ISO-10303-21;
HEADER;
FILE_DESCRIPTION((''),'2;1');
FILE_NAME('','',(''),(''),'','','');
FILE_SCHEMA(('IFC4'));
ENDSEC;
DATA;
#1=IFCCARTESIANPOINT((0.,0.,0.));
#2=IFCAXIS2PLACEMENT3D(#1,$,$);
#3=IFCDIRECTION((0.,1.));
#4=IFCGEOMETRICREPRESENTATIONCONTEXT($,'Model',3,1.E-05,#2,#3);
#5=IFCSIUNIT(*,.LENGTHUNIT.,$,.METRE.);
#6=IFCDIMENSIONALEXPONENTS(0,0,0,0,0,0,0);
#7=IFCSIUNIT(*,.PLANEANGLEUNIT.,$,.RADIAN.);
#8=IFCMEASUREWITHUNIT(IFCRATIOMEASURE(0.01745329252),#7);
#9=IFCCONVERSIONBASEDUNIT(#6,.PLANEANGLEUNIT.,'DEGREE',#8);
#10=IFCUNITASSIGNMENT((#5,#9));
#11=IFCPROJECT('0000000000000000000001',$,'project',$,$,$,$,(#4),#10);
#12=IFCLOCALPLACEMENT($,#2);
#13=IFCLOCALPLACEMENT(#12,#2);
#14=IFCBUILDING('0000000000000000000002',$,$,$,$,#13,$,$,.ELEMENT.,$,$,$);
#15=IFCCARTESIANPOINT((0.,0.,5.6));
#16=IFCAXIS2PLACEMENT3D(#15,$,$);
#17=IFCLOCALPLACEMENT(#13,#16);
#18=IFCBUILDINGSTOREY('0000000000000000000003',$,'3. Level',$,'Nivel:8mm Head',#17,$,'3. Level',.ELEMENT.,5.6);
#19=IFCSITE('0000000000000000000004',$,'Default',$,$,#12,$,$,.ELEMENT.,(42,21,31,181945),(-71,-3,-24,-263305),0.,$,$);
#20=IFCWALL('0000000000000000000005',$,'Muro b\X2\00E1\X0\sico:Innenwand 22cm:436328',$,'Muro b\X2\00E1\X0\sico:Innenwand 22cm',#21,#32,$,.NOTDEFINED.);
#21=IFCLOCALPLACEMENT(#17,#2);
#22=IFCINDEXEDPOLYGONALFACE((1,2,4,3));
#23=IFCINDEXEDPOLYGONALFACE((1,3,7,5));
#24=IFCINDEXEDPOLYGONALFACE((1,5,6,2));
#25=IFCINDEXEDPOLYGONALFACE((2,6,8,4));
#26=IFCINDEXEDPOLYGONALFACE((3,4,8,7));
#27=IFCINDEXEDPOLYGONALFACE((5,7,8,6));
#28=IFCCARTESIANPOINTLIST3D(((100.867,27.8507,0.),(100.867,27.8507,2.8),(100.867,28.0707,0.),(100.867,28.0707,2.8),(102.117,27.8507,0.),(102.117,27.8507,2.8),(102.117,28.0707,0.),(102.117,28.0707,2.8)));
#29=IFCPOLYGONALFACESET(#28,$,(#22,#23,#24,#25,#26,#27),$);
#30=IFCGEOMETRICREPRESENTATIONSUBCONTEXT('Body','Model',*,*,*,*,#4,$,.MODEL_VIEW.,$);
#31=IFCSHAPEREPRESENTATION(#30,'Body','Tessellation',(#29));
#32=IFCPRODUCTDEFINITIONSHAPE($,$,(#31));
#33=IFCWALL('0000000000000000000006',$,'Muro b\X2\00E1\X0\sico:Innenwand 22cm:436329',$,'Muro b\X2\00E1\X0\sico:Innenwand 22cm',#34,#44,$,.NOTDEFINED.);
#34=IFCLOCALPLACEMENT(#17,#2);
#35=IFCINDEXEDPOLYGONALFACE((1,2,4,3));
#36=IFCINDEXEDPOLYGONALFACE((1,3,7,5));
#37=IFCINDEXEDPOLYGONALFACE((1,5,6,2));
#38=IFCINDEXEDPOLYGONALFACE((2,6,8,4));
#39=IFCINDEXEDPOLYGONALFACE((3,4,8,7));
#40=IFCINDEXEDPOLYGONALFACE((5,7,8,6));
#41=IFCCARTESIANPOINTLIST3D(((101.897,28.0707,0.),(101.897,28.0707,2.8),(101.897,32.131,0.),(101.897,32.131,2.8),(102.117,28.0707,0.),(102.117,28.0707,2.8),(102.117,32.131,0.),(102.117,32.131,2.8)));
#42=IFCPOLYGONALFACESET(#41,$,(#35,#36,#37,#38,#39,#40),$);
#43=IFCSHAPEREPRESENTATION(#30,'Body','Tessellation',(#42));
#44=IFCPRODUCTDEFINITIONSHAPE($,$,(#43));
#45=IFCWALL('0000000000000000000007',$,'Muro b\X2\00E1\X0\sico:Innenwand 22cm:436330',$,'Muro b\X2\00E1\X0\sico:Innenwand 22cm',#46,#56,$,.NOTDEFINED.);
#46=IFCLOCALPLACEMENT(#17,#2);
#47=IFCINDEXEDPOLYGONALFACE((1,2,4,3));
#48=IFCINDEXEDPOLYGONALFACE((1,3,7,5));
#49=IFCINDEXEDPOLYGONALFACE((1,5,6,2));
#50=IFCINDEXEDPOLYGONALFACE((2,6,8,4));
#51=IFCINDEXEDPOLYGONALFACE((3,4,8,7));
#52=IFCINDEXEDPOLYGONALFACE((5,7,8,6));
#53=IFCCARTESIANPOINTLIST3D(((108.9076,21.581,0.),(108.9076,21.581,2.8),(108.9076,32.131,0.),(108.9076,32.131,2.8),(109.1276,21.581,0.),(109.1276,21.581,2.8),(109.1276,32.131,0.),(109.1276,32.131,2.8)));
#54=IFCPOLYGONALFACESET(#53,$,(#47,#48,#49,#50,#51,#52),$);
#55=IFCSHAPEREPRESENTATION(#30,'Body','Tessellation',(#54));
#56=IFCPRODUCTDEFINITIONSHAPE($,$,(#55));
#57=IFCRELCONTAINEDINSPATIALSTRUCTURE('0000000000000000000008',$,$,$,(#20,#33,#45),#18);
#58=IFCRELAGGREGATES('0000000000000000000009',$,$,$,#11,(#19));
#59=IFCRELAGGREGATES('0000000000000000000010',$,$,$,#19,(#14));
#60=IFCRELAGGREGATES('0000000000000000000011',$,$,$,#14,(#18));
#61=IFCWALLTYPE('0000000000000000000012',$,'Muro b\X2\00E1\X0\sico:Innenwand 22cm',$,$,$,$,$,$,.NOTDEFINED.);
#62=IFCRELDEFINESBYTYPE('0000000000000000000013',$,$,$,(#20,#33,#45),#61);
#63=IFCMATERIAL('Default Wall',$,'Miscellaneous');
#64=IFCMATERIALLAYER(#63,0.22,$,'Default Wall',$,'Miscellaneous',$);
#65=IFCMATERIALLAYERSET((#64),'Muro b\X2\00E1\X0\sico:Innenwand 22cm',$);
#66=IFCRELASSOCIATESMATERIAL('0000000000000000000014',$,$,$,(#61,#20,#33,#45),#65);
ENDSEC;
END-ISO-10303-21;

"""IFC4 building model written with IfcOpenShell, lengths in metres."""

from ifc_helpers import new_model, entity, si_unit, converted_unit, direction, frame, frame_2d, origin, place, context, subcontext, project, spatial, rectangle, extrude, material, layer, layer_set, layer_usage, type_object, element, save


model = new_model("IFC4")

# Units and contexts
model_context = context("Model", 3, precision=1e-05, world=origin(), true_north=direction((0.0, 1.0)))
body_context = subcontext(model_context, "Body", "Model", "MODEL_VIEW")
ifc_project = project(units=[si_unit("LENGTHUNIT", "METRE"), converted_unit("PLANEANGLEUNIT", "DEGREE", entity("IfcRatioMeasure", 0.01745329252), si_unit("PLANEANGLEUNIT", "RADIAN"), dimensions=[0, 0, 0, 0, 0, 0, 0])], contexts=[model_context])

# Site, building, storey
site_placement = place(None, origin())
site = spatial("IfcSite", under=ifc_project, at=site_placement, Name="Default", CompositionType="ELEMENT", RefLatitude=(42, 21, 31, 181945), RefLongitude=(-71, -3, -24, -263305), RefElevation=0.0)
building_placement = place(site_placement, origin())
building = spatial("IfcBuilding", under=site, at=building_placement, CompositionType="ELEMENT")
storey_placement = place(building_placement, frame((0.0, 0.0, 5.6)))
storey = spatial("IfcBuildingStorey", under=building, at=storey_placement, Name="3. Level", ObjectType="Nivel:8mm Head", LongName="3. Level", CompositionType="ELEMENT", Elevation=5.6)

# Walls
ifc_material_1 = material(Name="Default Wall", Category="Miscellaneous")
ifc_layer_1 = layer(ifc_material_1, 0.22, Name="Default Wall", Category="Miscellaneous")
ifc_layer_set_1 = layer_set([ifc_layer_1], Name="Muro básico:Innenwand 22cm")
wall_type_1 = type_object("IfcWallType", Name="Muro básico:Innenwand 22cm", PredefinedType="NOTDEFINED", material=ifc_layer_set_1)
ifc_layer_usage_1 = layer_usage(ifc_layer_set_1, "AXIS2", "NEGATIVE", 0.11)
wall_1_placement = place(storey_placement, frame((100.867, 27.9607, 0.0)))
element("IfcWall", 1, at=wall_1_placement, inside=storey, type_object=wall_type_1, material=ifc_layer_usage_1, Name="Muro básico:Innenwand 22cm:436328", ObjectType="Muro básico:Innenwand 22cm", PredefinedType="NOTDEFINED", context=body_context, shape_type="SweptSolid", body=[
    extrude(rectangle(XDim=1.25, YDim=0.22, at=frame_2d((0.625, 0.0), x_axis=(-1.0, 0.0))), origin(), (0.0, 0.0, 1.0), 2.8),
])
ifc_layer_usage_2 = layer_usage(ifc_layer_set_1, "AXIS2", "NEGATIVE", 0.11)
wall_2_placement = place(storey_placement, frame((102.007, 28.0707, 0.0), z_axis=(0.0, 0.0, 1.0), x_axis=(0.0, 1.0, 0.0)))
element("IfcWall", 2, at=wall_2_placement, inside=storey, type_object=wall_type_1, material=ifc_layer_usage_2, Name="Muro básico:Innenwand 22cm:436329", ObjectType="Muro básico:Innenwand 22cm", PredefinedType="NOTDEFINED", context=body_context, shape_type="SweptSolid", body=[
    extrude(rectangle(XDim=4.0603, YDim=0.22, at=frame_2d((2.0302, 0.0), x_axis=(-1.0, 0.0))), origin(), (0.0, 0.0, 1.0), 2.8),
])
ifc_layer_usage_3 = layer_usage(ifc_layer_set_1, "AXIS2", "NEGATIVE", 0.11)
wall_3_placement = place(storey_placement, frame((109.0176, 21.581, 0.0), z_axis=(0.0, 0.0, 1.0), x_axis=(0.0, 1.0, 0.0)))
element("IfcWall", 3, at=wall_3_placement, inside=storey, type_object=wall_type_1, material=ifc_layer_usage_3, Name="Muro básico:Innenwand 22cm:436330", ObjectType="Muro básico:Innenwand 22cm", PredefinedType="NOTDEFINED", context=body_context, shape_type="SweptSolid", body=[
    extrude(rectangle(XDim=10.55, YDim=0.22, at=frame_2d((5.275, 0.0), x_axis=(-1.0, 0.0))), origin(), (0.0, 0.0, 1.0), 2.8),
])

save(model, "model.ifc")
